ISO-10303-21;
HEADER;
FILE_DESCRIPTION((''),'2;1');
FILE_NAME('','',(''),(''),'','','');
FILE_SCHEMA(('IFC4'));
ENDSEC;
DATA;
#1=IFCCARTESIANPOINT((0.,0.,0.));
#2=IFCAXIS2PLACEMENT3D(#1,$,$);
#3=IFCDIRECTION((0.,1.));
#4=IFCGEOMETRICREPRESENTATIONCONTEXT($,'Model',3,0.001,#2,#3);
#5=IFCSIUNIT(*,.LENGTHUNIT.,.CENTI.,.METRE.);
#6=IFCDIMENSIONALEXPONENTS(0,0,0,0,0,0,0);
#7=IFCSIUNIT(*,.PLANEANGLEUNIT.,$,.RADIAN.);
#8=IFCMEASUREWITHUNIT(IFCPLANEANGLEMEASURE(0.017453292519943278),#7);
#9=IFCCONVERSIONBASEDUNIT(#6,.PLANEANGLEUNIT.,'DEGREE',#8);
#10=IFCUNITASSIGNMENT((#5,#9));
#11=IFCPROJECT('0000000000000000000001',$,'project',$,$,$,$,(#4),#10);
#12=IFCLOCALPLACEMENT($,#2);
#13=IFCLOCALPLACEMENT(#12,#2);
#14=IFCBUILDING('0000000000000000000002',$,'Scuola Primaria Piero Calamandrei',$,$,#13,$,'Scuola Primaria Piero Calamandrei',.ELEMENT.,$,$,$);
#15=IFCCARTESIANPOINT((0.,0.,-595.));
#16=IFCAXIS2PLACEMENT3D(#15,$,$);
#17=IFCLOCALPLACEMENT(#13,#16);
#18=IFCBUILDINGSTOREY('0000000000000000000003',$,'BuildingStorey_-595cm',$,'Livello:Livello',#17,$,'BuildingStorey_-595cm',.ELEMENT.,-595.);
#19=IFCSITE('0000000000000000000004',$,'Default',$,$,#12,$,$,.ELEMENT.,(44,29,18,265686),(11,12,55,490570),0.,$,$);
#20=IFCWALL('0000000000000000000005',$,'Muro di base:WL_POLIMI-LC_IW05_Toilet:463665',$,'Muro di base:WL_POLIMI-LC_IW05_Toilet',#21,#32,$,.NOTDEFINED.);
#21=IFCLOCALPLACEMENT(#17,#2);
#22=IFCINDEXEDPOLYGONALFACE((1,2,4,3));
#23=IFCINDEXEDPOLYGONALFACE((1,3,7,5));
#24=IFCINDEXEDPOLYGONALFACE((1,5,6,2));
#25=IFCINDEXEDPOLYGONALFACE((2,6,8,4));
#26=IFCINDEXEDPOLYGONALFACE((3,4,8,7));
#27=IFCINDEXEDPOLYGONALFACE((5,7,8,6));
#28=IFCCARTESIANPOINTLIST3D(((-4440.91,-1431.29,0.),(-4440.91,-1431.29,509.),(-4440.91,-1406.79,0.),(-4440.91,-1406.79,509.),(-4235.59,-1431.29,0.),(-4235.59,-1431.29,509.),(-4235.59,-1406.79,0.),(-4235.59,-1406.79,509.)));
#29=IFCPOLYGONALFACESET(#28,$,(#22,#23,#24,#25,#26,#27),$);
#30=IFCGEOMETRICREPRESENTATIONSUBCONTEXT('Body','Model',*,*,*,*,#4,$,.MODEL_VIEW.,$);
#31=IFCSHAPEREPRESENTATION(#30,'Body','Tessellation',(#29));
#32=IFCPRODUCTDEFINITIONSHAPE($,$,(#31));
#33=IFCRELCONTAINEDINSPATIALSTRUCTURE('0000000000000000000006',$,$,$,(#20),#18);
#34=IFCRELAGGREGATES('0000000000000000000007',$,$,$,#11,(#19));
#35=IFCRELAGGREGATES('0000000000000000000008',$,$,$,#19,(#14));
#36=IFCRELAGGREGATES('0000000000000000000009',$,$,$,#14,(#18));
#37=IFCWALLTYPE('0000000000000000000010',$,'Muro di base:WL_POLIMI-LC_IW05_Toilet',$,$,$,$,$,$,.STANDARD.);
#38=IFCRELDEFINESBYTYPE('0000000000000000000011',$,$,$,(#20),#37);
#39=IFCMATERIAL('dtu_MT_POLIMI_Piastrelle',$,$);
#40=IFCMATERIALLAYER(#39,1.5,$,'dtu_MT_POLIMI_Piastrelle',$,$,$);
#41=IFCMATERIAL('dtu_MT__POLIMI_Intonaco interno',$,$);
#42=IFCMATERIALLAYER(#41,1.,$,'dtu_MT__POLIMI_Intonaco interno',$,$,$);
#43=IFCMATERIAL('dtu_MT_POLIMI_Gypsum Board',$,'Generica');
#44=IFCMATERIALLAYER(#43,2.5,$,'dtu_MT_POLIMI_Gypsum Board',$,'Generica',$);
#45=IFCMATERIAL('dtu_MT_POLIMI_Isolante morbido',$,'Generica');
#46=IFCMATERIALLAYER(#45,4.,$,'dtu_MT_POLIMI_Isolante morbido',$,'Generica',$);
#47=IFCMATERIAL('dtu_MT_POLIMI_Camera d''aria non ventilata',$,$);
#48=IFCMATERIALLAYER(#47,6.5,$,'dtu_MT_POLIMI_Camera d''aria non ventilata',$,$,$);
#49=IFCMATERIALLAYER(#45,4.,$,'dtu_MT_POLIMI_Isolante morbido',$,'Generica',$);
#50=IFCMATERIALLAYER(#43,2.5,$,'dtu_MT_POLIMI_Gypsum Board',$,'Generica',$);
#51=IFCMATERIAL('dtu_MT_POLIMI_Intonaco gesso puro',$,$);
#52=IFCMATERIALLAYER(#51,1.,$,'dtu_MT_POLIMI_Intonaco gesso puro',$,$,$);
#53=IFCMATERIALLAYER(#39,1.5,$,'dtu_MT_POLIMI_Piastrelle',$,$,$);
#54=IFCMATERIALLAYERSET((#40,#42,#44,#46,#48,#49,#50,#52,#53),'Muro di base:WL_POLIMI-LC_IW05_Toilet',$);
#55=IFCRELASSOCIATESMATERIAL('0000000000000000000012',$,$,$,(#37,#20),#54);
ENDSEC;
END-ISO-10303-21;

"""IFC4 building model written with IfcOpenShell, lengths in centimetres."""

from ifc_helpers import new_model, entity, si_unit, converted_unit, direction, frame, frame_2d, origin, place, context, subcontext, project, spatial, rectangle, extrude, material, layer, layer_set, layer_usage, type_object, element, save


model = new_model("IFC4")

# Units and contexts
model_context = context("Model", 3, precision=0.001, world=origin(), true_north=direction((0.0, 1.0)))
body_context = subcontext(model_context, "Body", "Model", "MODEL_VIEW")
ifc_project = project(units=[si_unit("LENGTHUNIT", "METRE", prefix="CENTI"), converted_unit("PLANEANGLEUNIT", "DEGREE", entity("IfcPlaneAngleMeasure", 0.017453292519943278), si_unit("PLANEANGLEUNIT", "RADIAN"), dimensions=[0, 0, 0, 0, 0, 0, 0])], contexts=[model_context])

# Site, building, storey
site_placement = place(None, origin())
site = spatial("IfcSite", under=ifc_project, at=site_placement, Name="Default", CompositionType="ELEMENT", RefLatitude=(44, 29, 18, 265686), RefLongitude=(11, 12, 55, 490570), RefElevation=0.0)
building_placement = place(site_placement, origin())
building = spatial("IfcBuilding", under=site, at=building_placement, Name="Scuola Primaria Piero Calamandrei", LongName="Scuola Primaria Piero Calamandrei", CompositionType="ELEMENT")
storey_placement = place(building_placement, frame((0.0, 0.0, -595.0)))
storey = spatial("IfcBuildingStorey", under=building, at=storey_placement, Name="BuildingStorey_-595cm", ObjectType="Livello:Livello", LongName="BuildingStorey_-595cm", CompositionType="ELEMENT", Elevation=-595.0)

# Shared definitions
ifc_material_1 = material(Name="dtu_MT__POLIMI_Intonaco interno")

# Shared definitions
ifc_material_2 = material(Name="dtu_MT_POLIMI_Gypsum Board", Category="Generica")
ifc_material_3 = material(Name="dtu_MT_POLIMI_Isolante morbido", Category="Generica")
ifc_material_4 = material(Name="dtu_MT_POLIMI_Camera d'aria non ventilata")
ifc_material_5 = material(Name="dtu_MT_POLIMI_Intonaco gesso puro")

# Shared definitions
ifc_material_6 = material(Name="dtu_MT_POLIMI_Piastrelle")

# Shared definitions
ifc_layer_1 = layer(ifc_material_6, 1.5, Name="dtu_MT_POLIMI_Piastrelle")
ifc_layer_2 = layer(ifc_material_1, 1.0, Name="dtu_MT__POLIMI_Intonaco interno")
ifc_layer_3 = layer(ifc_material_2, 2.5, Name="dtu_MT_POLIMI_Gypsum Board", Category="Generica")
ifc_layer_4 = layer(ifc_material_3, 4.0, Name="dtu_MT_POLIMI_Isolante morbido", Category="Generica")
ifc_layer_5 = layer(ifc_material_4, 6.5, Name="dtu_MT_POLIMI_Camera d'aria non ventilata")
ifc_layer_6 = layer(ifc_material_3, 4.0, Name="dtu_MT_POLIMI_Isolante morbido", Category="Generica")
ifc_layer_7 = layer(ifc_material_2, 2.5, Name="dtu_MT_POLIMI_Gypsum Board", Category="Generica")
ifc_layer_8 = layer(ifc_material_5, 1.0, Name="dtu_MT_POLIMI_Intonaco gesso puro")
ifc_layer_9 = layer(ifc_material_6, 1.5, Name="dtu_MT_POLIMI_Piastrelle")
ifc_layer_set_1 = layer_set([ifc_layer_1, ifc_layer_2, ifc_layer_3, ifc_layer_4, ifc_layer_5, ifc_layer_6, ifc_layer_7, ifc_layer_8, ifc_layer_9], Name="Muro di base:WL_POLIMI-LC_IW05_Toilet")
wall_type_1 = type_object("IfcWallType", Name="Muro di base:WL_POLIMI-LC_IW05_Toilet", PredefinedType="STANDARD", material=ifc_layer_set_1)

# Wall
ifc_layer_usage_1 = layer_usage(ifc_layer_set_1, "AXIS2", "NEGATIVE", 12.25)
wall_1_placement = place(storey_placement, frame((-4440.91, -1419.04, 0.0)))
element("IfcWall", 1, at=wall_1_placement, inside=storey, type_object=wall_type_1, material=ifc_layer_usage_1, Name="Muro di base:WL_POLIMI-LC_IW05_Toilet:463665", ObjectType="Muro di base:WL_POLIMI-LC_IW05_Toilet", PredefinedType="NOTDEFINED", context=body_context, shape_type="SweptSolid", body=[
    extrude(rectangle(XDim=205.32, YDim=24.5, at=frame_2d((102.66, 0.0), x_axis=(-1.0, 0.0))), origin(), (0.0, 0.0, 1.0), 509.0),
])

save(model, "model.ifc")
